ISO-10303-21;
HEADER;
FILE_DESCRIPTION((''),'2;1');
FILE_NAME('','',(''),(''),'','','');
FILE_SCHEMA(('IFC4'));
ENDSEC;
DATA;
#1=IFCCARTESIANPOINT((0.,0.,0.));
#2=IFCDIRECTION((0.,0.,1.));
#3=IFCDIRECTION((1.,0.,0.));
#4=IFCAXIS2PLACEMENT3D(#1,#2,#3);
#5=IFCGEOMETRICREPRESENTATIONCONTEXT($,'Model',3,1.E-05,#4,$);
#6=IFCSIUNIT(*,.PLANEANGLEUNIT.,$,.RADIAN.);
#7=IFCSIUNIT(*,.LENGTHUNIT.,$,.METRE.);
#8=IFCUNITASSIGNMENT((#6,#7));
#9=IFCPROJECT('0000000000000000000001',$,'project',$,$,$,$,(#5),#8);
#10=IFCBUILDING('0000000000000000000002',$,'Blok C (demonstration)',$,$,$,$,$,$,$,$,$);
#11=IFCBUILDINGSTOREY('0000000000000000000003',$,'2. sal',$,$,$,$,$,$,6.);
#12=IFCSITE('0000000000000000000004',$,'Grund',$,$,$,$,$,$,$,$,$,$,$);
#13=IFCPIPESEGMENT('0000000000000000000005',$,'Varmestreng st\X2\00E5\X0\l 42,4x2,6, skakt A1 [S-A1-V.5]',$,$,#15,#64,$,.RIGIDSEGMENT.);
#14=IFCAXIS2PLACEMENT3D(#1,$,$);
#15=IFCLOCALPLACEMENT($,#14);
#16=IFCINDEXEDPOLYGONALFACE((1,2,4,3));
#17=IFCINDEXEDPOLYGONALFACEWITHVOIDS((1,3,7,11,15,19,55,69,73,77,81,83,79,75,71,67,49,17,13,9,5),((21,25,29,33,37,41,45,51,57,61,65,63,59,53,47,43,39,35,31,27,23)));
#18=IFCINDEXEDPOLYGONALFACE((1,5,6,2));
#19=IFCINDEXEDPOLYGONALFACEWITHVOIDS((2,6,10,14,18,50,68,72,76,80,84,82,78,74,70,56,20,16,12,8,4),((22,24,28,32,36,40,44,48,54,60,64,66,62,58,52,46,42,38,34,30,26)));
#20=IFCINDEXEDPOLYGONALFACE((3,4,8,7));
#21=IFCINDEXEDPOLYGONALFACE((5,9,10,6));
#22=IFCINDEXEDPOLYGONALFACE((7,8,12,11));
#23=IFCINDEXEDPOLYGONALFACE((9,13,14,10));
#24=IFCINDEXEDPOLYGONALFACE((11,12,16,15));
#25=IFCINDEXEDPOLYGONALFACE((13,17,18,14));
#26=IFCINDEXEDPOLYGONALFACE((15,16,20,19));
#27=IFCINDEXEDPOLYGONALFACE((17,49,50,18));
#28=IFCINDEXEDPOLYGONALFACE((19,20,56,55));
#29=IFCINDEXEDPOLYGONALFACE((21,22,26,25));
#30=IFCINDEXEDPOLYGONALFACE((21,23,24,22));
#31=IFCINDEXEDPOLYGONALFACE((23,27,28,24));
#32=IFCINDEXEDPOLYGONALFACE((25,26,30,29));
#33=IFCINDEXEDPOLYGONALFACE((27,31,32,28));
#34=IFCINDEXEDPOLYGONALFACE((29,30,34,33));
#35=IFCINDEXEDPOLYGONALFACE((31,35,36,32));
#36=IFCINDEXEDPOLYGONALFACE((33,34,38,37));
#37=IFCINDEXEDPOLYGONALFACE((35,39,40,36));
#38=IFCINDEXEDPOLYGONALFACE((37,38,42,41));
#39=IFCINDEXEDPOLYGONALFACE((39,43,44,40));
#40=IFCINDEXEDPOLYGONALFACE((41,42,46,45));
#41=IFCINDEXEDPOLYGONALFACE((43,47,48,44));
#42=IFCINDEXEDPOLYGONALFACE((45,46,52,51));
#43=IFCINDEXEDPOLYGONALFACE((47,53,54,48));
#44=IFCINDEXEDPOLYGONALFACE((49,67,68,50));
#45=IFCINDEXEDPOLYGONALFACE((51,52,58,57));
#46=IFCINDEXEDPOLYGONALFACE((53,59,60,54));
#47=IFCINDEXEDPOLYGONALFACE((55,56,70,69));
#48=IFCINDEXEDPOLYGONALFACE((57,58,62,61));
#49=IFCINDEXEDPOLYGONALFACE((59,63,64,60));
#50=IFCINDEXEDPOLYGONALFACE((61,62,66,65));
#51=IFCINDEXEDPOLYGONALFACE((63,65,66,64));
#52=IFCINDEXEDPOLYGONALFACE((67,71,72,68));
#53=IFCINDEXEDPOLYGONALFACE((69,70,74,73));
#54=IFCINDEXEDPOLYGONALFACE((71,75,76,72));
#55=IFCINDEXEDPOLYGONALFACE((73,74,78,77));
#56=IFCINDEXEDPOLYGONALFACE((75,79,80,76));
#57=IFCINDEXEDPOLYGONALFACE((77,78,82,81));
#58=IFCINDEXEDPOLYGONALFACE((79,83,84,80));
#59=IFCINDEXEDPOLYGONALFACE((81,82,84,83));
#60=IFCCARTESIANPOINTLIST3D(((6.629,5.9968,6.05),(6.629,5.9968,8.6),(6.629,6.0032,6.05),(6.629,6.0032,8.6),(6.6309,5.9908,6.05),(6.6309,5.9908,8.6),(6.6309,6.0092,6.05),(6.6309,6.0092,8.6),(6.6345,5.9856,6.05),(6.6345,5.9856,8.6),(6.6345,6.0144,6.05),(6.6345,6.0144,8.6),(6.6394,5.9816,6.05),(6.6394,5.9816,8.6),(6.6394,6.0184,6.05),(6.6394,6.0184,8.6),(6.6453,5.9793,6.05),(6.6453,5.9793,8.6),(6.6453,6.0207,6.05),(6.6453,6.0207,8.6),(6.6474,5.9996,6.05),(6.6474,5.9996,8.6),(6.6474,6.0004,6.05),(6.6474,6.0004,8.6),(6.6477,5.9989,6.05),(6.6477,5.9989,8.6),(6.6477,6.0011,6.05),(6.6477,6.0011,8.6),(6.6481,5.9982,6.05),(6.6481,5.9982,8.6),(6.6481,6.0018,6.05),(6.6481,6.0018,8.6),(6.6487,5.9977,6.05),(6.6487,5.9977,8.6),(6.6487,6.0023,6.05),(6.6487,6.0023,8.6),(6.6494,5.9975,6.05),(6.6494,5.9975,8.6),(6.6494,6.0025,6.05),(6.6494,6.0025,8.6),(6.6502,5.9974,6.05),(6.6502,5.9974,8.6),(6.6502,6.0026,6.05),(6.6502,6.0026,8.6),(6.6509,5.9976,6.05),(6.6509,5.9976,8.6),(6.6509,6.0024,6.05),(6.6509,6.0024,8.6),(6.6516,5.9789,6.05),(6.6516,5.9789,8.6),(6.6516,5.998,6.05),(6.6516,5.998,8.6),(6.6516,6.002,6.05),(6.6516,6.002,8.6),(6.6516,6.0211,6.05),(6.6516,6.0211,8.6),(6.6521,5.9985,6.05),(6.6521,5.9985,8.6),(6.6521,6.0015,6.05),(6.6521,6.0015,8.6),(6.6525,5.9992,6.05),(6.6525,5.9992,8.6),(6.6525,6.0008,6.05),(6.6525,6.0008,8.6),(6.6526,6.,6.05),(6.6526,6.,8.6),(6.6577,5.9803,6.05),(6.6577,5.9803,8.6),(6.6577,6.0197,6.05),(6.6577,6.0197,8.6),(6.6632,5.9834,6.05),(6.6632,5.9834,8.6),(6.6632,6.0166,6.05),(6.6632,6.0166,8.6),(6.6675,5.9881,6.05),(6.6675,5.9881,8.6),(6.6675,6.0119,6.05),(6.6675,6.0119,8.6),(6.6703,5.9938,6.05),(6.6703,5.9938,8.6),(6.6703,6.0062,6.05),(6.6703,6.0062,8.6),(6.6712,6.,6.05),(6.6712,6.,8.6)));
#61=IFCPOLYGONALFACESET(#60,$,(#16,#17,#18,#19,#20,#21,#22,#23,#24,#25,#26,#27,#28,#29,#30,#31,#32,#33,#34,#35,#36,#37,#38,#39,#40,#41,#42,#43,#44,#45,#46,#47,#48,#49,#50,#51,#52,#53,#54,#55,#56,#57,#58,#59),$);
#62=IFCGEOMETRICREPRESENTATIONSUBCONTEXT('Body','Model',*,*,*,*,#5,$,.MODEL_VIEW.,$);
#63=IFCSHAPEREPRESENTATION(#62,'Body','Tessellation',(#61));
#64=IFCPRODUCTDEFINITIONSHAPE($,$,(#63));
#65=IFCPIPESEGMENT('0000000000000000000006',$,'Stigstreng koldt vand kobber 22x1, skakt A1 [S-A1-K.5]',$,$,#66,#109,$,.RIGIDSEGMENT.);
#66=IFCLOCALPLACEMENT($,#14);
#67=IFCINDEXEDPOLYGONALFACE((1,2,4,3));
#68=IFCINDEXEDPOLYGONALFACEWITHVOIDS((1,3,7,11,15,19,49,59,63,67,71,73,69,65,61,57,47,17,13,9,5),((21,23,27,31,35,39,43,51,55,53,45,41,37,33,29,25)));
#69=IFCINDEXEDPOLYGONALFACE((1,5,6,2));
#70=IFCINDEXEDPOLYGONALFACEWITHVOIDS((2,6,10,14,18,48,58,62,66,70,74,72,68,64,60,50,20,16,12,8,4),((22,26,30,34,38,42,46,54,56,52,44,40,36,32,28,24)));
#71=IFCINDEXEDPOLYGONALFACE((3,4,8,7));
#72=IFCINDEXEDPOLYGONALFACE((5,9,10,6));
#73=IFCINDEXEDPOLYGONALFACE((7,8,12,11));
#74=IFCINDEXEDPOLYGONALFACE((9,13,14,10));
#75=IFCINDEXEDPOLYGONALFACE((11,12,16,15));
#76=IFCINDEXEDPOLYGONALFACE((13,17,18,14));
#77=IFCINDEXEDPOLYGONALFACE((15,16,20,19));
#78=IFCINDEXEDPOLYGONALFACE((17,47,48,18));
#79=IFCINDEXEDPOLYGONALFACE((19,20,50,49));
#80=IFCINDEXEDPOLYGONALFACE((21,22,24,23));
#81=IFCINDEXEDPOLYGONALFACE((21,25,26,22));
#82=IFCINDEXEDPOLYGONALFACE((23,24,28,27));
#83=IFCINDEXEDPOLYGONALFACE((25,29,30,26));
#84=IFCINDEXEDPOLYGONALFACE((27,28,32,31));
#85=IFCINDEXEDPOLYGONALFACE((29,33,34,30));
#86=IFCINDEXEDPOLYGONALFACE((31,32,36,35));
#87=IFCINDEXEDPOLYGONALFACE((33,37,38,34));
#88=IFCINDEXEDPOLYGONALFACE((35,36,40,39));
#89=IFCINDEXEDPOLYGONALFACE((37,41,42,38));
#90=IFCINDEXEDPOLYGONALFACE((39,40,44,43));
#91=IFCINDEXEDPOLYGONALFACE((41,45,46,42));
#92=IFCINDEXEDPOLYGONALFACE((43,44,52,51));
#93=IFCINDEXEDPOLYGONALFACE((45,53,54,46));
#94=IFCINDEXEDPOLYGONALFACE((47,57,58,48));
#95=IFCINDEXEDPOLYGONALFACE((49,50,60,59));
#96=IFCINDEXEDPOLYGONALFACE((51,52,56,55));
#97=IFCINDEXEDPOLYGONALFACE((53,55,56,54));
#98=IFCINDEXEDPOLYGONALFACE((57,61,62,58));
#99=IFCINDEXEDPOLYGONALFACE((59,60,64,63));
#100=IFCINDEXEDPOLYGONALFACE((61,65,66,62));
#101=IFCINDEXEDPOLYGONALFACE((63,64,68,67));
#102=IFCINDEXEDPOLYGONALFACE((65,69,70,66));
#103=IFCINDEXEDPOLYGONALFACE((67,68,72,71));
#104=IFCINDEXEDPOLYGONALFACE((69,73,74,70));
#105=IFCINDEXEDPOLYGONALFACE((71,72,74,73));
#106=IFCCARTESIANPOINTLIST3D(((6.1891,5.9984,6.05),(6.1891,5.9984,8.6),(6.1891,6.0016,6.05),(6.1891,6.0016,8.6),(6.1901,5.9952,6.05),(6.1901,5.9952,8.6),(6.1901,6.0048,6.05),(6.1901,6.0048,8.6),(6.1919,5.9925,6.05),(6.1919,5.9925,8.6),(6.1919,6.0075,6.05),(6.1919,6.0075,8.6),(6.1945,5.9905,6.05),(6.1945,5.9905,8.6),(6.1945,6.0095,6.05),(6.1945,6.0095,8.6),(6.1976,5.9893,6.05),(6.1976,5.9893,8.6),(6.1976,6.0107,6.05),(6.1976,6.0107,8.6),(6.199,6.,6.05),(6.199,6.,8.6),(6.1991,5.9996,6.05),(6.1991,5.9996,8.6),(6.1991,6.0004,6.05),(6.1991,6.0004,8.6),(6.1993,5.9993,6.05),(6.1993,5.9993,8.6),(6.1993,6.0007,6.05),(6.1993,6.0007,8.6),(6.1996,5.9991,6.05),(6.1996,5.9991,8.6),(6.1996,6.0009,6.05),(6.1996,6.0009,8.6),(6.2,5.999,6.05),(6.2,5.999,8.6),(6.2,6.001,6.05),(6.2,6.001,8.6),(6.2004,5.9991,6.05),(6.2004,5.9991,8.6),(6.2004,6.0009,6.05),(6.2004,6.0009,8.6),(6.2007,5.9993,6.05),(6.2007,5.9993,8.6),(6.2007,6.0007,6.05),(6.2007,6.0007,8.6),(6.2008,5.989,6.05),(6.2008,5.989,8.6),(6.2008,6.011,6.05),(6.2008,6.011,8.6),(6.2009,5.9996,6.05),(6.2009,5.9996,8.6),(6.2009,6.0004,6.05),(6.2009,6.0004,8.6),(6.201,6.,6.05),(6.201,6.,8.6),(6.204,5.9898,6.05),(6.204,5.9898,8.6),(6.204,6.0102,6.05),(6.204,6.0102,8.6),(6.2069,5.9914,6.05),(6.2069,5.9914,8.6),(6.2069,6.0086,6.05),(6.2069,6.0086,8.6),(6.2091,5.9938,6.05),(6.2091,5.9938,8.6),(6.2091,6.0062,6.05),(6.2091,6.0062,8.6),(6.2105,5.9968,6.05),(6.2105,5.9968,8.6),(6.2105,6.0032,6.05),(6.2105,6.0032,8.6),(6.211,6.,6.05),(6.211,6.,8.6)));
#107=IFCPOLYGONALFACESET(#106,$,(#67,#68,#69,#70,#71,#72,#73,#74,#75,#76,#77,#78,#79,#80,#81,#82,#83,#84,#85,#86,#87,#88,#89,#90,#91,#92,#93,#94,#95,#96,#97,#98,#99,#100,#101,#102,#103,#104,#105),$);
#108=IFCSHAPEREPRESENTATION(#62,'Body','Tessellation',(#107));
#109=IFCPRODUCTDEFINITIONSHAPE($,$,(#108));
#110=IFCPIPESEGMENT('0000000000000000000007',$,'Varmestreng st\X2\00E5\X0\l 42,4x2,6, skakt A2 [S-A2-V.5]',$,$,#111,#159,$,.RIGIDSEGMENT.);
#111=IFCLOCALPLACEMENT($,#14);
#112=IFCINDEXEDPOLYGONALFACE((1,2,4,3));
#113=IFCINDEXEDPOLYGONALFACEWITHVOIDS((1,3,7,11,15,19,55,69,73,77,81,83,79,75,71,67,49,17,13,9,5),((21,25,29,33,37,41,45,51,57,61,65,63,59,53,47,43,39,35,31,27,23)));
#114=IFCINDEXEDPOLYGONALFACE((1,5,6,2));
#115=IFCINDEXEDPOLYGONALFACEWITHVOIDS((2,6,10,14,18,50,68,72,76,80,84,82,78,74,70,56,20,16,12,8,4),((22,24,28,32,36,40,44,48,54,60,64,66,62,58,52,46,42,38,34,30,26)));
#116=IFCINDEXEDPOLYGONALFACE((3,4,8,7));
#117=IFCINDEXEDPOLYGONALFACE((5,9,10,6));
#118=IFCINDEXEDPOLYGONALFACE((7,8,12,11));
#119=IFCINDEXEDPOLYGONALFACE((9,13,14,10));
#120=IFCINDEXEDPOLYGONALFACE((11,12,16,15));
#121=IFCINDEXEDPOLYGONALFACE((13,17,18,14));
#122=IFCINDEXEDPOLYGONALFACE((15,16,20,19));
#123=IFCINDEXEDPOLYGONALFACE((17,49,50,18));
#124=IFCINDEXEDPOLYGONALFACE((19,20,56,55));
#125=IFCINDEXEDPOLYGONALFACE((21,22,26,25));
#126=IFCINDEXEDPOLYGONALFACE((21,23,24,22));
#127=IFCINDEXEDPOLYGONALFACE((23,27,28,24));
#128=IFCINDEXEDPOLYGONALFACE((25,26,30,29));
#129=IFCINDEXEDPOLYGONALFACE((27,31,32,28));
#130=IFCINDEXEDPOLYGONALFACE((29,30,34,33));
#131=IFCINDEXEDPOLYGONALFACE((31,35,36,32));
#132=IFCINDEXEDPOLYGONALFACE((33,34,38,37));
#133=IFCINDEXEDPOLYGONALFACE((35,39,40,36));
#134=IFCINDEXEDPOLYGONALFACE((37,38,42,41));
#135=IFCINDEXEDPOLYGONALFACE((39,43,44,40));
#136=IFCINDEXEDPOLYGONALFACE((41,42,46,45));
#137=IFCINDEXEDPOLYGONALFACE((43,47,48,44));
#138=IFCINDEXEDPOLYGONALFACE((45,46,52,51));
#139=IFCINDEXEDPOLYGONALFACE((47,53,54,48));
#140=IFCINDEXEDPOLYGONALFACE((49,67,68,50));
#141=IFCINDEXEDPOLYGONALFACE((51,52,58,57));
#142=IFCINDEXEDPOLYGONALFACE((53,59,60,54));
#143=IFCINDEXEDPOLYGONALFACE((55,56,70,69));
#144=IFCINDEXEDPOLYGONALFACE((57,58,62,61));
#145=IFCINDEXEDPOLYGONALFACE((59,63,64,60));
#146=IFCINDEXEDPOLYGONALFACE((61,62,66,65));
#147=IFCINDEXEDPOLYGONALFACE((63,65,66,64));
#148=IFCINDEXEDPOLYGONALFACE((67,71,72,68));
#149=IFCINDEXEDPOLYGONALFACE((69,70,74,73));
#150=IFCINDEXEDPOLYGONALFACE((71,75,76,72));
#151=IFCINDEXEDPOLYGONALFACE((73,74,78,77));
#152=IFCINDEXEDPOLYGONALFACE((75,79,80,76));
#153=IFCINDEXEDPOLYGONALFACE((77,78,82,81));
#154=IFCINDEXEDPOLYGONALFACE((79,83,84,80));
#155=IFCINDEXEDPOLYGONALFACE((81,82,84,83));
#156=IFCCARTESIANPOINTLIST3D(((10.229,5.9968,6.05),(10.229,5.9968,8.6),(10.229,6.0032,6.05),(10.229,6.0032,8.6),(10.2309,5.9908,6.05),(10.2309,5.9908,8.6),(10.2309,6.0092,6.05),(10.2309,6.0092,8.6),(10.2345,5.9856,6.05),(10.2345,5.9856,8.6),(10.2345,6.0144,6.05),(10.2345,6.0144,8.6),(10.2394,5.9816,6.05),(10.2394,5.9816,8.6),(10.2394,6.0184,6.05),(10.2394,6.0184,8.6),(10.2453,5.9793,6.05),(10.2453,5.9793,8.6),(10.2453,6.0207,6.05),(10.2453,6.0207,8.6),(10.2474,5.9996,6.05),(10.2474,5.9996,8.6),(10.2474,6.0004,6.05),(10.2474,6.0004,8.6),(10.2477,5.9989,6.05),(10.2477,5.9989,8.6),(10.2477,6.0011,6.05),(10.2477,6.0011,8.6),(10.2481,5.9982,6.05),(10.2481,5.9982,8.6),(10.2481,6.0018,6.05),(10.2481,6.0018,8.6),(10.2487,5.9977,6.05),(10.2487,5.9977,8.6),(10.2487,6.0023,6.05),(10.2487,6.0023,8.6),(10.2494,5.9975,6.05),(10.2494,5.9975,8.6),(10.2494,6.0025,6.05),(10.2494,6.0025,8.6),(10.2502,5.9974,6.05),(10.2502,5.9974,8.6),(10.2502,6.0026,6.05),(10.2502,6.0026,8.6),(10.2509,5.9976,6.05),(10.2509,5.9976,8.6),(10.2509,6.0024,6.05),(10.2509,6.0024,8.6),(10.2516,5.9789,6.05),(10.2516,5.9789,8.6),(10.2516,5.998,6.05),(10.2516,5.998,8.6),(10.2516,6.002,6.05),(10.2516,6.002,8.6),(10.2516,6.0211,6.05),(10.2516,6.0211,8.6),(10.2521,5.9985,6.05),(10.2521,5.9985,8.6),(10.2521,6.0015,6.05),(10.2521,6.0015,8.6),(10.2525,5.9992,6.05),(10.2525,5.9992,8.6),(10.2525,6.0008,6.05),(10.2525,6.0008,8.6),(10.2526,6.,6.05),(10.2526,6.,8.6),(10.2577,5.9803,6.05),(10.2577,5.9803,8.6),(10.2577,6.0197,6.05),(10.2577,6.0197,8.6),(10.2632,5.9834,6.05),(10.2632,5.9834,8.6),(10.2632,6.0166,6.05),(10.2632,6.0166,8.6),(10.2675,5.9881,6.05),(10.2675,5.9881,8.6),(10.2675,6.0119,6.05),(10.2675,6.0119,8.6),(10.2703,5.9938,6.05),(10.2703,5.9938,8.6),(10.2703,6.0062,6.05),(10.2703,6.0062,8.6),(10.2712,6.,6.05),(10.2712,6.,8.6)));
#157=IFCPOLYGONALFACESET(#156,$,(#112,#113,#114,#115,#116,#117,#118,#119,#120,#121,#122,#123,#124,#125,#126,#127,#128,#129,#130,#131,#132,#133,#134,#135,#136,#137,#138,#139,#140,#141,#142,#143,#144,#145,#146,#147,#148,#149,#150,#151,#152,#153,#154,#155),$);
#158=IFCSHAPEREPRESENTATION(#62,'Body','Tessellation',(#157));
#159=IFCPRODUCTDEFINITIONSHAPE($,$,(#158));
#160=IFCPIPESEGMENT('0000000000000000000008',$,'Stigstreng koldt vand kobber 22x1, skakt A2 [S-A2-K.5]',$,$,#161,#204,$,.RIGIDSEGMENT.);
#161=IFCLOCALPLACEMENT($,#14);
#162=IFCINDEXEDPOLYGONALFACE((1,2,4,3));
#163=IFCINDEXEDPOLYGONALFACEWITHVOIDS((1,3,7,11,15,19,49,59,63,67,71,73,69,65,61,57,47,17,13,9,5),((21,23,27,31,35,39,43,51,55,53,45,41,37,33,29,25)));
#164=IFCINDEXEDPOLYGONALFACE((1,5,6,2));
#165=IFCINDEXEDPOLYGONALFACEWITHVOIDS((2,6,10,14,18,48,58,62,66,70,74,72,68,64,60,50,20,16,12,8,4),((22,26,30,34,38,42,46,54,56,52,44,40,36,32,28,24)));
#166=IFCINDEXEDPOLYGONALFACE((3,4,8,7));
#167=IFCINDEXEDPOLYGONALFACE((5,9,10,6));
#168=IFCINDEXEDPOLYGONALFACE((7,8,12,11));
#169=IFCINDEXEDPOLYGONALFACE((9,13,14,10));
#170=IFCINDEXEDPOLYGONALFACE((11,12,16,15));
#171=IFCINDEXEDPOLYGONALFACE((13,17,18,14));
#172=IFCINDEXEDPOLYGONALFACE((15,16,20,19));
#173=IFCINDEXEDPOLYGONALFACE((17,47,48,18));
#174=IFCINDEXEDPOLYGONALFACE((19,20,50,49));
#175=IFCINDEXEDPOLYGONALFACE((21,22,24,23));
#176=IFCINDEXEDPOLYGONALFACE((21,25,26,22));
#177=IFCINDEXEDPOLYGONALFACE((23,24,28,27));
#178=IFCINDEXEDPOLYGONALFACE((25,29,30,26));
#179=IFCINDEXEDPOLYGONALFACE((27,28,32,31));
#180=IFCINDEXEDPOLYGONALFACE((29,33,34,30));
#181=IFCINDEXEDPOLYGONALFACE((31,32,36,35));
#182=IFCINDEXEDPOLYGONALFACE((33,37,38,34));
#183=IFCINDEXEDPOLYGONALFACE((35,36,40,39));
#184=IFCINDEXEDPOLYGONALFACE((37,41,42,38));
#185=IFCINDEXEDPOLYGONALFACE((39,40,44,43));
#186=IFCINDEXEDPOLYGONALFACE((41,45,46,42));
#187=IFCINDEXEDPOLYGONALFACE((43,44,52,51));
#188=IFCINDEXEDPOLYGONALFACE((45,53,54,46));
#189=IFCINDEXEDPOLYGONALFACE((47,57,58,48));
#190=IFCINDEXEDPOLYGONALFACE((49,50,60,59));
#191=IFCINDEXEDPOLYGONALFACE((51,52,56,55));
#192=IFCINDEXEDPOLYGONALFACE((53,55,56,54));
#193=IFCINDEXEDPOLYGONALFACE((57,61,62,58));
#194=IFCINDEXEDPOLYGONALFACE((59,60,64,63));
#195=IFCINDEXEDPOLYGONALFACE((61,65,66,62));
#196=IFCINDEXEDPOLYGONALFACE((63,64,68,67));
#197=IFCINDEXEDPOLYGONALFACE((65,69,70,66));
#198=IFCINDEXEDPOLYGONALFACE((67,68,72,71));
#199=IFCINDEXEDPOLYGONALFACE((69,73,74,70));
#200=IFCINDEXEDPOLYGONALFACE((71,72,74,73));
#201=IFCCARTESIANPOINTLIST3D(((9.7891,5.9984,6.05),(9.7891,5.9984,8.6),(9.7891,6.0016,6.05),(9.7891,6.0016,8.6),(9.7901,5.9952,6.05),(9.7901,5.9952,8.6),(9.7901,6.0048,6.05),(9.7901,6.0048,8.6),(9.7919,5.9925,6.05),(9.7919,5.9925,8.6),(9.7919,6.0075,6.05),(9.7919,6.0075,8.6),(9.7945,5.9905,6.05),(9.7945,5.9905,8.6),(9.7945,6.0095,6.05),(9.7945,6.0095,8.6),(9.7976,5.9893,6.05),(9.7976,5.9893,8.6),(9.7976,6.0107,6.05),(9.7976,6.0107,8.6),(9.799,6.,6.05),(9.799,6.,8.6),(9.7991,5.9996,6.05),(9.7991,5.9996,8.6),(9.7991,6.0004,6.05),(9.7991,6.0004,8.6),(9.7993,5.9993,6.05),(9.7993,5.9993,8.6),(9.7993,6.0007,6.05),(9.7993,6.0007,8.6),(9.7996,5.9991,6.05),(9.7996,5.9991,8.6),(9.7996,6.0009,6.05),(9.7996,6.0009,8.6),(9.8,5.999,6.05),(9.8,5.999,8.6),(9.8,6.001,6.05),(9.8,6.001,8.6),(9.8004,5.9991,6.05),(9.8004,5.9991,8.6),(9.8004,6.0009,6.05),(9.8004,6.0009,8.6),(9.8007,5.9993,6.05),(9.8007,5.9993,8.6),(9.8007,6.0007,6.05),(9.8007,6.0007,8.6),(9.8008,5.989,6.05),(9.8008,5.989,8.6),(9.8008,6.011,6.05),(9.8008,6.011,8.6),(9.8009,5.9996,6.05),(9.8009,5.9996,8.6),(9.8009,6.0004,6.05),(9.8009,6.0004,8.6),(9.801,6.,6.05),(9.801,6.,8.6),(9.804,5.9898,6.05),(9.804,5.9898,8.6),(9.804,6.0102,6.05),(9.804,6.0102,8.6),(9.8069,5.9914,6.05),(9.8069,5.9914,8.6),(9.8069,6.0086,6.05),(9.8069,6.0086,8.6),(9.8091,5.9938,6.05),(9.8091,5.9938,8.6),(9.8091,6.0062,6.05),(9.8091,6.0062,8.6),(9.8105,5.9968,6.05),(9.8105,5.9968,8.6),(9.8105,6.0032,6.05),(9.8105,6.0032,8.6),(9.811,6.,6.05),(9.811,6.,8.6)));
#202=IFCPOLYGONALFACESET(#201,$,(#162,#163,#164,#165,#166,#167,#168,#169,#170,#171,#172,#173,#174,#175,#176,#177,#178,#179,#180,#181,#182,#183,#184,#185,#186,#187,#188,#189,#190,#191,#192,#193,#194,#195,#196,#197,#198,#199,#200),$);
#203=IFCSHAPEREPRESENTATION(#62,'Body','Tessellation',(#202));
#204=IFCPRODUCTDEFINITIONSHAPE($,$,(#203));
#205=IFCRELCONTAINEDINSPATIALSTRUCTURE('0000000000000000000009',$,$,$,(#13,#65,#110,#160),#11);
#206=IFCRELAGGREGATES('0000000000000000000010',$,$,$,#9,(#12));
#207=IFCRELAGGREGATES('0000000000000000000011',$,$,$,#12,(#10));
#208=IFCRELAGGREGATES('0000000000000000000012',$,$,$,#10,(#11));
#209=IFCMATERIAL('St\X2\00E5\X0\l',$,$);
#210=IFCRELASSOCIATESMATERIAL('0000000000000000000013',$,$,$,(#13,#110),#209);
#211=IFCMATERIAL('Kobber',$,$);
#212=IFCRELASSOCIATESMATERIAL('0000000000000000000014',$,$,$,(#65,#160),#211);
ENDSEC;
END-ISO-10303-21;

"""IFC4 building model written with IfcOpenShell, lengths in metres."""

from ifc_helpers import new_model, si_unit, frame, origin_with_axes, place, context, subcontext, project, spatial, hollow_circle, extrude, material, element, save


model = new_model("IFC4")

# Units and contexts
model_context = context("Model", 3, precision=1e-05, world=origin_with_axes())
body_context = subcontext(model_context, "Body", "Model", "MODEL_VIEW")
ifc_project = project(units=[si_unit("PLANEANGLEUNIT", "RADIAN"), si_unit("LENGTHUNIT", "METRE")], contexts=[model_context])

# Site, building, storey
site = spatial("IfcSite", under=ifc_project, Name="Grund")
building = spatial("IfcBuilding", under=site, Name="Blok C (demonstration)")
storey = spatial("IfcBuildingStorey", under=building, Name="2. sal", Elevation=6.0)

# Pipe segments
ifc_material_1 = material(Name="Stål")
pipe_segment_1_placement = place(None, origin_with_axes())
element("IfcPipeSegment", 1, at=pipe_segment_1_placement, inside=storey, material=ifc_material_1, Name="Varmestreng stål 42,4x2,6, skakt A1 [S-A1-V.5]", PredefinedType="RIGIDSEGMENT", context=body_context, shape_type="SweptSolid", body=[
    extrude(hollow_circle(Radius=0.0212, WallThickness=0.0186), frame((6.65, 6.0, 6.05), z_axis=(0.0, 0.0, 1.0), x_axis=(1.0, 0.0, 0.0)), (0.0, 0.0, 1.0), 2.55),
])
ifc_material_2 = material(Name="Kobber")
pipe_segment_2_placement = place(None, origin_with_axes())
element("IfcPipeSegment", 2, at=pipe_segment_2_placement, inside=storey, material=ifc_material_2, Name="Stigstreng koldt vand kobber 22x1, skakt A1 [S-A1-K.5]", PredefinedType="RIGIDSEGMENT", context=body_context, shape_type="SweptSolid", body=[
    extrude(hollow_circle(Radius=0.011, WallThickness=0.01), frame((6.2, 6.0, 6.05), z_axis=(0.0, 0.0, 1.0), x_axis=(1.0, 0.0, 0.0)), (0.0, 0.0, 1.0), 2.55),
])
pipe_segment_3_placement = place(None, origin_with_axes())
element("IfcPipeSegment", 3, at=pipe_segment_3_placement, inside=storey, material=ifc_material_1, Name="Varmestreng stål 42,4x2,6, skakt A2 [S-A2-V.5]", PredefinedType="RIGIDSEGMENT", context=body_context, shape_type="SweptSolid", body=[
    extrude(hollow_circle(Radius=0.0212, WallThickness=0.0186), frame((10.25, 6.0, 6.05), z_axis=(0.0, 0.0, 1.0), x_axis=(1.0, 0.0, 0.0)), (0.0, 0.0, 1.0), 2.55),
])
pipe_segment_4_placement = place(None, origin_with_axes())
element("IfcPipeSegment", 4, at=pipe_segment_4_placement, inside=storey, material=ifc_material_2, Name="Stigstreng koldt vand kobber 22x1, skakt A2 [S-A2-K.5]", PredefinedType="RIGIDSEGMENT", context=body_context, shape_type="SweptSolid", body=[
    extrude(hollow_circle(Radius=0.011, WallThickness=0.01), frame((9.8, 6.0, 6.05), z_axis=(0.0, 0.0, 1.0), x_axis=(1.0, 0.0, 0.0)), (0.0, 0.0, 1.0), 2.55),
])

save(model, "model.ifc")
